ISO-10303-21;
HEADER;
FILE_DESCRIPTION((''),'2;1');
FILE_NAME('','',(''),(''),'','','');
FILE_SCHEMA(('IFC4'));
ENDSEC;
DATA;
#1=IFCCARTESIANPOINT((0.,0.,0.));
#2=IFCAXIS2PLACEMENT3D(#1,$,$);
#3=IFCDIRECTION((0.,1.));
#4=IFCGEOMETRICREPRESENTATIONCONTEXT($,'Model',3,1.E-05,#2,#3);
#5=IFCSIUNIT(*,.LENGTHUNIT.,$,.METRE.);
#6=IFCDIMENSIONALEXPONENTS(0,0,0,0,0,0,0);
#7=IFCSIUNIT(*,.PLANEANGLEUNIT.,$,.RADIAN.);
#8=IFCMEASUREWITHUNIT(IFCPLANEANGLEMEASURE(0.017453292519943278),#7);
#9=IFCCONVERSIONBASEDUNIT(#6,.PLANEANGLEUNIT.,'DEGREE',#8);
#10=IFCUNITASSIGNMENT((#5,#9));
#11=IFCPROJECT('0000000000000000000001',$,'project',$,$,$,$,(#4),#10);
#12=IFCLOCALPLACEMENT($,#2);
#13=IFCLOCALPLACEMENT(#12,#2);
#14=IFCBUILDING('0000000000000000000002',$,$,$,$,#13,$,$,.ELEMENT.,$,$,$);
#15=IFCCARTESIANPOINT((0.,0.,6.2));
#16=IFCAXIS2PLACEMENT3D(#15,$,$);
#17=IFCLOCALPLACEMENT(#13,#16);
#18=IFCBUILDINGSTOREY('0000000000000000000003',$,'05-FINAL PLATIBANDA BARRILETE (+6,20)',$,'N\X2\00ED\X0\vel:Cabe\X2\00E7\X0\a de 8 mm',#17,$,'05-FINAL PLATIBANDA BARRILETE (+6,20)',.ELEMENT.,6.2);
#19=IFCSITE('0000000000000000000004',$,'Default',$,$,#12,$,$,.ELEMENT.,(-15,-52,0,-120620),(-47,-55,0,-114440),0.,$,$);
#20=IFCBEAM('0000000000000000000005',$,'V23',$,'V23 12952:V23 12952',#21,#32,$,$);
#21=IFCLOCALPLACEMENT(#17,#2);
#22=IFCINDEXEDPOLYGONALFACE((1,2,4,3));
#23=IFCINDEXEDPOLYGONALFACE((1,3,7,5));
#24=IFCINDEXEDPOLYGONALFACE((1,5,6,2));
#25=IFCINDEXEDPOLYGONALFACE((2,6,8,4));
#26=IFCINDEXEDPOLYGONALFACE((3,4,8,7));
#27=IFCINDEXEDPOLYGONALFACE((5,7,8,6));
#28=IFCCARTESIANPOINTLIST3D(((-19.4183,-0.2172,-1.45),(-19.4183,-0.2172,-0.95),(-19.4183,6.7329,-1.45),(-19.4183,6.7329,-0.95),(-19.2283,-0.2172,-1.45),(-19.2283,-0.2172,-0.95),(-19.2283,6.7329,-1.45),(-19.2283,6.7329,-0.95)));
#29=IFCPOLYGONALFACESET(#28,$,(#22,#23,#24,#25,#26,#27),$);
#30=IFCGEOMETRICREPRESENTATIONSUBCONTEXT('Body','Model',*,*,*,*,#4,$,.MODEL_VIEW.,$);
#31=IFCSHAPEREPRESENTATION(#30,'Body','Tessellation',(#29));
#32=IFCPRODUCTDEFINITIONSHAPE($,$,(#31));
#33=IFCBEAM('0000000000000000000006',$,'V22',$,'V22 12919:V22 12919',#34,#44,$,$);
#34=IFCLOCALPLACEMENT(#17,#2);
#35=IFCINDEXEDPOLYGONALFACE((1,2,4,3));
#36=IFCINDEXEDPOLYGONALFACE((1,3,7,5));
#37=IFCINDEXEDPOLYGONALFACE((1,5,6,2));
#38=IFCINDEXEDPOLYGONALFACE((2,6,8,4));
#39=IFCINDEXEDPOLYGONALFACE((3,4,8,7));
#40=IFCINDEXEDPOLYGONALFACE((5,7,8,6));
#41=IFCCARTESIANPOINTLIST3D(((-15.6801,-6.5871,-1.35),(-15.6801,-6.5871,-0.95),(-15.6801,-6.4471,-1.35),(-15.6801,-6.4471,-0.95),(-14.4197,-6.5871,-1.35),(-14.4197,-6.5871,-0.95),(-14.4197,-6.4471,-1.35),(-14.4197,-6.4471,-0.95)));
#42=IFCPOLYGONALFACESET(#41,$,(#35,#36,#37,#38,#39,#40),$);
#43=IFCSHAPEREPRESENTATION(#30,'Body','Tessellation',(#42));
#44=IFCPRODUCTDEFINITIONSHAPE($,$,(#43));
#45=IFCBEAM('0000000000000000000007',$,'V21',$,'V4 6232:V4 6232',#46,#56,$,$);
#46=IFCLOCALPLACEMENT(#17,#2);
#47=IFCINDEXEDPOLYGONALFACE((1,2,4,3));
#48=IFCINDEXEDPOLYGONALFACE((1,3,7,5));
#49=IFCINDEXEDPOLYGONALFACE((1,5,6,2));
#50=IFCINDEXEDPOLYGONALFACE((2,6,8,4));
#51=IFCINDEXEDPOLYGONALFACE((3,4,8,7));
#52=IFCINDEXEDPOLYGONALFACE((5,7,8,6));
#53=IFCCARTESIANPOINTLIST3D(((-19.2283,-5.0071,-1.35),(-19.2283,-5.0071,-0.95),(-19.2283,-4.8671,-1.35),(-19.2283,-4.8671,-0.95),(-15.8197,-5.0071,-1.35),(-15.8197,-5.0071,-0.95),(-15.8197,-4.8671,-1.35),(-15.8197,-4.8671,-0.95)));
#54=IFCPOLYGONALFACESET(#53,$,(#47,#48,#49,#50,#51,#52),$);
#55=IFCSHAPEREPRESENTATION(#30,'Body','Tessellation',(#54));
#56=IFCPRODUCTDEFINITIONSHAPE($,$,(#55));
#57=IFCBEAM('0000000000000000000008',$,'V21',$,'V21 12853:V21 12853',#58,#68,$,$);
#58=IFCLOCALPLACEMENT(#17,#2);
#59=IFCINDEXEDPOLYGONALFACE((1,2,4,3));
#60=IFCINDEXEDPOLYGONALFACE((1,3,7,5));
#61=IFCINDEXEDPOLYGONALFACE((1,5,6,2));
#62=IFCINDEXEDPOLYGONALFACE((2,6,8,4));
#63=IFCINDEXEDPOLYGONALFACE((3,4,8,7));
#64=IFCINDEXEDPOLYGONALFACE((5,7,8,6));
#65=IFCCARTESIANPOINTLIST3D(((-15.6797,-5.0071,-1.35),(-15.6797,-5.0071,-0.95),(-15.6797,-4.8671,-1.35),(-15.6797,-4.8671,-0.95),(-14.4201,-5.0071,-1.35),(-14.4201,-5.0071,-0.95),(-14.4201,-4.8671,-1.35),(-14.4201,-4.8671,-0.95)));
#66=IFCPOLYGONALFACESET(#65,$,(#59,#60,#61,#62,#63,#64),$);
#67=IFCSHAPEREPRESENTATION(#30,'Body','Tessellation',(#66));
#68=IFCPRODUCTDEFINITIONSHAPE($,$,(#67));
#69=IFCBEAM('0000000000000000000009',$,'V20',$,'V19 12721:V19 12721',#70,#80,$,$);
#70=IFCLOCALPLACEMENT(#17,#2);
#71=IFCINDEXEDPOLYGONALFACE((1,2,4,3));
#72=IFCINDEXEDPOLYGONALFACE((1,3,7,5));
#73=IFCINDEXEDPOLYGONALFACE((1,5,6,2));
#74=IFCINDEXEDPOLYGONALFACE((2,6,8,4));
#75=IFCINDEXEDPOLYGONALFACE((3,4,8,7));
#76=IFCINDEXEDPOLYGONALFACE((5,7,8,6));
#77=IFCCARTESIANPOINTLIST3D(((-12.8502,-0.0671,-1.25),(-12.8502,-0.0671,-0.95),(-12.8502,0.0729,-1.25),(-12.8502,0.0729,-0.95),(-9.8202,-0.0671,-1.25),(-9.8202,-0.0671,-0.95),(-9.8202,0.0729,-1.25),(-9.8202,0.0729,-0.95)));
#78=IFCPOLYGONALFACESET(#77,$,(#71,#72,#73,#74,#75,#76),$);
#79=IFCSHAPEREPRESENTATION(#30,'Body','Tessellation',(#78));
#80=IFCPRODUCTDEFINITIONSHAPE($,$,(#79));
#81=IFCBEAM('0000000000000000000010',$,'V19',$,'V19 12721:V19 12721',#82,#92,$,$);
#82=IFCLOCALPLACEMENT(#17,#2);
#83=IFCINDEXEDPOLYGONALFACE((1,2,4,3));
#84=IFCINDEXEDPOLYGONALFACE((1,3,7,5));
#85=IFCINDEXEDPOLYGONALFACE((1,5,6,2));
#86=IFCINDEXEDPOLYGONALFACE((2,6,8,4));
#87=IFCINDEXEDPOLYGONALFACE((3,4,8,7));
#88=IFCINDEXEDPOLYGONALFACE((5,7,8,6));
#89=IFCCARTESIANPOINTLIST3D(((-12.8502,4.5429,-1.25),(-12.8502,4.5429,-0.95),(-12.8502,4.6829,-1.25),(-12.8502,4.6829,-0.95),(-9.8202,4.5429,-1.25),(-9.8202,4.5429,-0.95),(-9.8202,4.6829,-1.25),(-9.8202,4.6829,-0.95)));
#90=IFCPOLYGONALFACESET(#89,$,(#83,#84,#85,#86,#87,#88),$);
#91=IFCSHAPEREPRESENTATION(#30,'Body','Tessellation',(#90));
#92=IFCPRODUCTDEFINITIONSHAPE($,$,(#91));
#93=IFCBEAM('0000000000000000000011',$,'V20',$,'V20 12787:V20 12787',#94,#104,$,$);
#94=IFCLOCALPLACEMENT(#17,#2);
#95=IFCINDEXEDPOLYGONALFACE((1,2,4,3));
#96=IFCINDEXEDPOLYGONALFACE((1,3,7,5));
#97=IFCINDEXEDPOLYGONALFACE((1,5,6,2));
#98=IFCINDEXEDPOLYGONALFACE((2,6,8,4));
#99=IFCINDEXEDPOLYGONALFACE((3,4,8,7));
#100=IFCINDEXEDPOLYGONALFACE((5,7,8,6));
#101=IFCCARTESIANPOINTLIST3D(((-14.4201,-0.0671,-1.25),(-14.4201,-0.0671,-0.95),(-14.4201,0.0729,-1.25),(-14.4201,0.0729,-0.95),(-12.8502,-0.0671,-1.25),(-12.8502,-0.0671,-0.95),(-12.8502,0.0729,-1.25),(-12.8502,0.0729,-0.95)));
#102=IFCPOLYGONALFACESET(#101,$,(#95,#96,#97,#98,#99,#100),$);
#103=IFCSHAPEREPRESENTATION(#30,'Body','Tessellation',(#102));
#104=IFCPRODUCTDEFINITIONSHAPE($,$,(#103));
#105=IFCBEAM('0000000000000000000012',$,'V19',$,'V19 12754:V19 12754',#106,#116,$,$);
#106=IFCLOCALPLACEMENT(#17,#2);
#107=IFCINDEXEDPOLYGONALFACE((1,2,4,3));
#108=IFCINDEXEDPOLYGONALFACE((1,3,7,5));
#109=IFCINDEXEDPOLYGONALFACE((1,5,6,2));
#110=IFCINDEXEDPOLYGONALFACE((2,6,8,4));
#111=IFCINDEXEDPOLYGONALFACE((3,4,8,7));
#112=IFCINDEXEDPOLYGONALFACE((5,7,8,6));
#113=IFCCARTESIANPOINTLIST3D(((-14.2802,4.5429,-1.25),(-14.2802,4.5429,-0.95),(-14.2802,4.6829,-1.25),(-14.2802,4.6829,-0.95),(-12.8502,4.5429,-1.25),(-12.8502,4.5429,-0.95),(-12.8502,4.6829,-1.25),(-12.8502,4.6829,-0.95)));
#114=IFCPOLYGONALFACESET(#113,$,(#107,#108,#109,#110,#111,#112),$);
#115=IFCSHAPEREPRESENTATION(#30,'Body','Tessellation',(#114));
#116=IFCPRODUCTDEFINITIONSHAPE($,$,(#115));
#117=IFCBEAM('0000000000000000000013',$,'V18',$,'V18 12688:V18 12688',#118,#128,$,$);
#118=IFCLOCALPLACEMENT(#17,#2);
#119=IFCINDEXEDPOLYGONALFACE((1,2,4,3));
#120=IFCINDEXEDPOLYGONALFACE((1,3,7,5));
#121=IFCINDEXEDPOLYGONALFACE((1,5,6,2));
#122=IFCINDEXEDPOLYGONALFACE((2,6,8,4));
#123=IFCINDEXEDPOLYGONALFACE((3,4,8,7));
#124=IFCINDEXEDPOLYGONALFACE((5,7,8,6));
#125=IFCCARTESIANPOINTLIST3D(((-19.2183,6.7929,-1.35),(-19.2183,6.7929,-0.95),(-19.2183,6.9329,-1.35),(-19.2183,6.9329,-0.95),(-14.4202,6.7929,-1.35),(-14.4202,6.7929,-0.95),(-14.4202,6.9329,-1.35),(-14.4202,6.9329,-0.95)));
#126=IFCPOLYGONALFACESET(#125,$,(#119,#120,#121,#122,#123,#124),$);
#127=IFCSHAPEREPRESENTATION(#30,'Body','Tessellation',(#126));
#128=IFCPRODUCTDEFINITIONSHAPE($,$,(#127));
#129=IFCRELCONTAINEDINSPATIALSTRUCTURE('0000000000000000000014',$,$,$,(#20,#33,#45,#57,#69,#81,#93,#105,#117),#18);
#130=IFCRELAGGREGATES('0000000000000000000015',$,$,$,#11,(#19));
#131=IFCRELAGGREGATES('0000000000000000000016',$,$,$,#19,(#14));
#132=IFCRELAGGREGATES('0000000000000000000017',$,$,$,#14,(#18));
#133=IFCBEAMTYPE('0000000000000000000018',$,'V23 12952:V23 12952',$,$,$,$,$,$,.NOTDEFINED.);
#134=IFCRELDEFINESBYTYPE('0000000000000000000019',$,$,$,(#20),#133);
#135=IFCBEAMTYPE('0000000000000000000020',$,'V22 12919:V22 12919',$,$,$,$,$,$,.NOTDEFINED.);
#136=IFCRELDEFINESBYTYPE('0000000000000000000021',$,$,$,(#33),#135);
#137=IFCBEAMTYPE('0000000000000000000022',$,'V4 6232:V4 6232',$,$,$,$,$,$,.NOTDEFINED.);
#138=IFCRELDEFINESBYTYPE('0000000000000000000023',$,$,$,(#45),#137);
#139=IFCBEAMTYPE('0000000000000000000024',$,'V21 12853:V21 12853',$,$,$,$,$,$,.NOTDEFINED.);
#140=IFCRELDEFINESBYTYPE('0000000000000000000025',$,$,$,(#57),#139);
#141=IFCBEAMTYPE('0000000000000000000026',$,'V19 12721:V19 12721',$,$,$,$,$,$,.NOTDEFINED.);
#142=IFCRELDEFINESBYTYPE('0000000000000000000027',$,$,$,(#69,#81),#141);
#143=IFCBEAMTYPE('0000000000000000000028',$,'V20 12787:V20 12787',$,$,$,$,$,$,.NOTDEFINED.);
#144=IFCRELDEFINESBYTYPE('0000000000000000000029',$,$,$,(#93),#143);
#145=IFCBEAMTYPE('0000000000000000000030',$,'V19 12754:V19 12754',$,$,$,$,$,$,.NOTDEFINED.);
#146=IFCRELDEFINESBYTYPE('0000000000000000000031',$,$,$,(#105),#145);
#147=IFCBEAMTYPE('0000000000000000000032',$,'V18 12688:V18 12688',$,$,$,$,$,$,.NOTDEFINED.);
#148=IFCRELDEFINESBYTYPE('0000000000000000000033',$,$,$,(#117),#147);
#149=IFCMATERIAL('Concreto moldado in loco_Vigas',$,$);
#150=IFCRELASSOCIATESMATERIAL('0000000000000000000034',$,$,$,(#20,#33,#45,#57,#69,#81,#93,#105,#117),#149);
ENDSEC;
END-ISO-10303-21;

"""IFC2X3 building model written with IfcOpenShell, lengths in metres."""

from ifc_helpers import new_model, entity, si_unit, converted_unit, direction, frame, frame_2d, origin, place, context, subcontext, project, spatial, rectangle, extrude, material, type_object, element, save


model = new_model("IFC2X3")

# Units and contexts
model_context = context("Model", 3, precision=1e-05, world=origin(), true_north=direction((0.0, 1.0)))
body_context = subcontext(model_context, "Body", "Model", "MODEL_VIEW")
ifc_project = project(units=[si_unit("LENGTHUNIT", "METRE"), converted_unit("PLANEANGLEUNIT", "DEGREE", entity("IfcPlaneAngleMeasure", 0.017453292519943278), si_unit("PLANEANGLEUNIT", "RADIAN"), dimensions=[0, 0, 0, 0, 0, 0, 0])], contexts=[model_context])

# Site, building, storey
site_placement = place(None, origin())
site = spatial("IfcSite", under=ifc_project, at=site_placement, Name="Default", CompositionType="ELEMENT", RefLatitude=(-15, -52, 0, -120620), RefLongitude=(-47, -55, 0, -114440), RefElevation=0.0)
building_placement = place(site_placement, origin())
building = spatial("IfcBuilding", under=site, at=building_placement, CompositionType="ELEMENT")
storey_placement = place(building_placement, frame((0.0, 0.0, 6.2)))
storey = spatial("IfcBuildingStorey", under=building, at=storey_placement, Name="05-FINAL PLATIBANDA BARRILETE (+6,20)", ObjectType="Nível:Cabeça de 8 mm", LongName="05-FINAL PLATIBANDA BARRILETE (+6,20)", CompositionType="ELEMENT", Elevation=6.2)

# Beams
ifc_material_1 = material(Name="Concreto moldado in loco_Vigas")
beam_type_1 = type_object("IfcBeamType", Name="V23 12952:V23 12952", PredefinedType="NOTDEFINED")
beam_1_placement = place(storey_placement, origin())
element("IfcBeam", 1, at=beam_1_placement, inside=storey, type_object=beam_type_1, material=ifc_material_1, Name="V23", ObjectType="V23 12952:V23 12952", context=body_context, shape_type="SweptSolid", body=[
    extrude(rectangle(XDim=0.5, YDim=6.9501, at=frame_2d((0.0, 0.0), x_axis=(0.0, 1.0))), frame((-19.4183, 3.2579, -1.2), z_axis=(1.0, 0.0, 0.0), x_axis=(0.0, -1.0, 0.0)), (0.0, 0.0, 1.0), 0.19),
])
beam_type_2 = type_object("IfcBeamType", Name="V22 12919:V22 12919", PredefinedType="NOTDEFINED")
beam_2_placement = place(storey_placement, origin())
element("IfcBeam", 2, at=beam_2_placement, inside=storey, type_object=beam_type_2, material=ifc_material_1, Name="V22", ObjectType="V22 12919:V22 12919", context=body_context, shape_type="SweptSolid", body=[
    extrude(rectangle(XDim=0.4, YDim=0.14, at=frame_2d((0.0, 0.0), x_axis=(1.0, 0.0))), frame((-15.6801, -6.5171, -1.15), z_axis=(1.0, 0.0, 0.0), x_axis=(0.0, 0.0, -1.0)), (0.0, 0.0, 1.0), 1.2604),
])
beam_type_3 = type_object("IfcBeamType", Name="V4 6232:V4 6232", PredefinedType="NOTDEFINED")
beam_3_placement = place(storey_placement, origin())
element("IfcBeam", 3, at=beam_3_placement, inside=storey, type_object=beam_type_3, material=ifc_material_1, Name="V21", ObjectType="V4 6232:V4 6232", context=body_context, shape_type="SweptSolid", body=[
    extrude(rectangle(XDim=0.4, YDim=0.14, at=frame_2d((0.0, 0.0), x_axis=(1.0, 0.0))), frame((-19.2283, -4.9371, -1.15), z_axis=(1.0, 0.0, 0.0), x_axis=(0.0, 0.0, -1.0)), (0.0, 0.0, 1.0), 3.4086),
])
beam_type_4 = type_object("IfcBeamType", Name="V21 12853:V21 12853", PredefinedType="NOTDEFINED")
beam_4_placement = place(storey_placement, origin())
element("IfcBeam", 4, at=beam_4_placement, inside=storey, type_object=beam_type_4, material=ifc_material_1, Name="V21", ObjectType="V21 12853:V21 12853", context=body_context, shape_type="SweptSolid", body=[
    extrude(rectangle(XDim=0.4, YDim=0.14, at=frame_2d((0.0, 0.0), x_axis=(1.0, 0.0))), frame((-15.6797, -4.9371, -1.15), z_axis=(1.0, 0.0, 0.0), x_axis=(0.0, 0.0, -1.0)), (0.0, 0.0, 1.0), 1.2596),
])
beam_type_5 = type_object("IfcBeamType", Name="V19 12721:V19 12721", PredefinedType="NOTDEFINED")
beam_5_placement = place(storey_placement, origin())
element("IfcBeam", 5, at=beam_5_placement, inside=storey, type_object=beam_type_5, material=ifc_material_1, Name="V20", ObjectType="V19 12721:V19 12721", context=body_context, shape_type="SweptSolid", body=[
    extrude(rectangle(XDim=0.3, YDim=0.14, at=frame_2d((0.0, 0.0), x_axis=(1.0, 0.0))), frame((-12.8502, 0.0029, -1.1), z_axis=(1.0, 0.0, 0.0), x_axis=(0.0, 0.0, -1.0)), (0.0, 0.0, 1.0), 3.03),
])
beam_6_placement = place(storey_placement, origin())
element("IfcBeam", 6, at=beam_6_placement, inside=storey, type_object=beam_type_5, material=ifc_material_1, Name="V19", ObjectType="V19 12721:V19 12721", context=body_context, shape_type="SweptSolid", body=[
    extrude(rectangle(XDim=0.3, YDim=0.14, at=frame_2d((0.0, 0.0), x_axis=(1.0, 0.0))), frame((-12.8502, 4.6129, -1.1), z_axis=(1.0, 0.0, 0.0), x_axis=(0.0, 0.0, -1.0)), (0.0, 0.0, 1.0), 3.03),
])
beam_type_6 = type_object("IfcBeamType", Name="V20 12787:V20 12787", PredefinedType="NOTDEFINED")
beam_7_placement = place(storey_placement, origin())
element("IfcBeam", 7, at=beam_7_placement, inside=storey, type_object=beam_type_6, material=ifc_material_1, Name="V20", ObjectType="V20 12787:V20 12787", context=body_context, shape_type="SweptSolid", body=[
    extrude(rectangle(XDim=0.3, YDim=0.14, at=frame_2d((0.0, 0.0), x_axis=(1.0, 0.0))), frame((-14.4201, 0.0029, -1.1), z_axis=(1.0, 0.0, 0.0), x_axis=(0.0, 0.0, -1.0)), (0.0, 0.0, 1.0), 1.5699),
])
beam_type_7 = type_object("IfcBeamType", Name="V19 12754:V19 12754", PredefinedType="NOTDEFINED")
beam_8_placement = place(storey_placement, origin())
element("IfcBeam", 8, at=beam_8_placement, inside=storey, type_object=beam_type_7, material=ifc_material_1, Name="V19", ObjectType="V19 12754:V19 12754", context=body_context, shape_type="SweptSolid", body=[
    extrude(rectangle(XDim=0.3, YDim=0.14, at=frame_2d((0.0, 0.0), x_axis=(1.0, 0.0))), frame((-14.2802, 4.6129, -1.1), z_axis=(1.0, 0.0, 0.0), x_axis=(0.0, 0.0, -1.0)), (0.0, 0.0, 1.0), 1.43),
])
beam_type_8 = type_object("IfcBeamType", Name="V18 12688:V18 12688", PredefinedType="NOTDEFINED")
beam_9_placement = place(storey_placement, origin())
element("IfcBeam", 9, at=beam_9_placement, inside=storey, type_object=beam_type_8, material=ifc_material_1, Name="V18", ObjectType="V18 12688:V18 12688", context=body_context, shape_type="SweptSolid", body=[
    extrude(rectangle(XDim=0.4, YDim=0.14, at=frame_2d((0.0, 0.0), x_axis=(1.0, 0.0))), frame((-19.2183, 6.8629, -1.15), z_axis=(1.0, 0.0, 0.0), x_axis=(0.0, 0.0, -1.0)), (0.0, 0.0, 1.0), 4.7981),
])

save(model, "model.ifc")
